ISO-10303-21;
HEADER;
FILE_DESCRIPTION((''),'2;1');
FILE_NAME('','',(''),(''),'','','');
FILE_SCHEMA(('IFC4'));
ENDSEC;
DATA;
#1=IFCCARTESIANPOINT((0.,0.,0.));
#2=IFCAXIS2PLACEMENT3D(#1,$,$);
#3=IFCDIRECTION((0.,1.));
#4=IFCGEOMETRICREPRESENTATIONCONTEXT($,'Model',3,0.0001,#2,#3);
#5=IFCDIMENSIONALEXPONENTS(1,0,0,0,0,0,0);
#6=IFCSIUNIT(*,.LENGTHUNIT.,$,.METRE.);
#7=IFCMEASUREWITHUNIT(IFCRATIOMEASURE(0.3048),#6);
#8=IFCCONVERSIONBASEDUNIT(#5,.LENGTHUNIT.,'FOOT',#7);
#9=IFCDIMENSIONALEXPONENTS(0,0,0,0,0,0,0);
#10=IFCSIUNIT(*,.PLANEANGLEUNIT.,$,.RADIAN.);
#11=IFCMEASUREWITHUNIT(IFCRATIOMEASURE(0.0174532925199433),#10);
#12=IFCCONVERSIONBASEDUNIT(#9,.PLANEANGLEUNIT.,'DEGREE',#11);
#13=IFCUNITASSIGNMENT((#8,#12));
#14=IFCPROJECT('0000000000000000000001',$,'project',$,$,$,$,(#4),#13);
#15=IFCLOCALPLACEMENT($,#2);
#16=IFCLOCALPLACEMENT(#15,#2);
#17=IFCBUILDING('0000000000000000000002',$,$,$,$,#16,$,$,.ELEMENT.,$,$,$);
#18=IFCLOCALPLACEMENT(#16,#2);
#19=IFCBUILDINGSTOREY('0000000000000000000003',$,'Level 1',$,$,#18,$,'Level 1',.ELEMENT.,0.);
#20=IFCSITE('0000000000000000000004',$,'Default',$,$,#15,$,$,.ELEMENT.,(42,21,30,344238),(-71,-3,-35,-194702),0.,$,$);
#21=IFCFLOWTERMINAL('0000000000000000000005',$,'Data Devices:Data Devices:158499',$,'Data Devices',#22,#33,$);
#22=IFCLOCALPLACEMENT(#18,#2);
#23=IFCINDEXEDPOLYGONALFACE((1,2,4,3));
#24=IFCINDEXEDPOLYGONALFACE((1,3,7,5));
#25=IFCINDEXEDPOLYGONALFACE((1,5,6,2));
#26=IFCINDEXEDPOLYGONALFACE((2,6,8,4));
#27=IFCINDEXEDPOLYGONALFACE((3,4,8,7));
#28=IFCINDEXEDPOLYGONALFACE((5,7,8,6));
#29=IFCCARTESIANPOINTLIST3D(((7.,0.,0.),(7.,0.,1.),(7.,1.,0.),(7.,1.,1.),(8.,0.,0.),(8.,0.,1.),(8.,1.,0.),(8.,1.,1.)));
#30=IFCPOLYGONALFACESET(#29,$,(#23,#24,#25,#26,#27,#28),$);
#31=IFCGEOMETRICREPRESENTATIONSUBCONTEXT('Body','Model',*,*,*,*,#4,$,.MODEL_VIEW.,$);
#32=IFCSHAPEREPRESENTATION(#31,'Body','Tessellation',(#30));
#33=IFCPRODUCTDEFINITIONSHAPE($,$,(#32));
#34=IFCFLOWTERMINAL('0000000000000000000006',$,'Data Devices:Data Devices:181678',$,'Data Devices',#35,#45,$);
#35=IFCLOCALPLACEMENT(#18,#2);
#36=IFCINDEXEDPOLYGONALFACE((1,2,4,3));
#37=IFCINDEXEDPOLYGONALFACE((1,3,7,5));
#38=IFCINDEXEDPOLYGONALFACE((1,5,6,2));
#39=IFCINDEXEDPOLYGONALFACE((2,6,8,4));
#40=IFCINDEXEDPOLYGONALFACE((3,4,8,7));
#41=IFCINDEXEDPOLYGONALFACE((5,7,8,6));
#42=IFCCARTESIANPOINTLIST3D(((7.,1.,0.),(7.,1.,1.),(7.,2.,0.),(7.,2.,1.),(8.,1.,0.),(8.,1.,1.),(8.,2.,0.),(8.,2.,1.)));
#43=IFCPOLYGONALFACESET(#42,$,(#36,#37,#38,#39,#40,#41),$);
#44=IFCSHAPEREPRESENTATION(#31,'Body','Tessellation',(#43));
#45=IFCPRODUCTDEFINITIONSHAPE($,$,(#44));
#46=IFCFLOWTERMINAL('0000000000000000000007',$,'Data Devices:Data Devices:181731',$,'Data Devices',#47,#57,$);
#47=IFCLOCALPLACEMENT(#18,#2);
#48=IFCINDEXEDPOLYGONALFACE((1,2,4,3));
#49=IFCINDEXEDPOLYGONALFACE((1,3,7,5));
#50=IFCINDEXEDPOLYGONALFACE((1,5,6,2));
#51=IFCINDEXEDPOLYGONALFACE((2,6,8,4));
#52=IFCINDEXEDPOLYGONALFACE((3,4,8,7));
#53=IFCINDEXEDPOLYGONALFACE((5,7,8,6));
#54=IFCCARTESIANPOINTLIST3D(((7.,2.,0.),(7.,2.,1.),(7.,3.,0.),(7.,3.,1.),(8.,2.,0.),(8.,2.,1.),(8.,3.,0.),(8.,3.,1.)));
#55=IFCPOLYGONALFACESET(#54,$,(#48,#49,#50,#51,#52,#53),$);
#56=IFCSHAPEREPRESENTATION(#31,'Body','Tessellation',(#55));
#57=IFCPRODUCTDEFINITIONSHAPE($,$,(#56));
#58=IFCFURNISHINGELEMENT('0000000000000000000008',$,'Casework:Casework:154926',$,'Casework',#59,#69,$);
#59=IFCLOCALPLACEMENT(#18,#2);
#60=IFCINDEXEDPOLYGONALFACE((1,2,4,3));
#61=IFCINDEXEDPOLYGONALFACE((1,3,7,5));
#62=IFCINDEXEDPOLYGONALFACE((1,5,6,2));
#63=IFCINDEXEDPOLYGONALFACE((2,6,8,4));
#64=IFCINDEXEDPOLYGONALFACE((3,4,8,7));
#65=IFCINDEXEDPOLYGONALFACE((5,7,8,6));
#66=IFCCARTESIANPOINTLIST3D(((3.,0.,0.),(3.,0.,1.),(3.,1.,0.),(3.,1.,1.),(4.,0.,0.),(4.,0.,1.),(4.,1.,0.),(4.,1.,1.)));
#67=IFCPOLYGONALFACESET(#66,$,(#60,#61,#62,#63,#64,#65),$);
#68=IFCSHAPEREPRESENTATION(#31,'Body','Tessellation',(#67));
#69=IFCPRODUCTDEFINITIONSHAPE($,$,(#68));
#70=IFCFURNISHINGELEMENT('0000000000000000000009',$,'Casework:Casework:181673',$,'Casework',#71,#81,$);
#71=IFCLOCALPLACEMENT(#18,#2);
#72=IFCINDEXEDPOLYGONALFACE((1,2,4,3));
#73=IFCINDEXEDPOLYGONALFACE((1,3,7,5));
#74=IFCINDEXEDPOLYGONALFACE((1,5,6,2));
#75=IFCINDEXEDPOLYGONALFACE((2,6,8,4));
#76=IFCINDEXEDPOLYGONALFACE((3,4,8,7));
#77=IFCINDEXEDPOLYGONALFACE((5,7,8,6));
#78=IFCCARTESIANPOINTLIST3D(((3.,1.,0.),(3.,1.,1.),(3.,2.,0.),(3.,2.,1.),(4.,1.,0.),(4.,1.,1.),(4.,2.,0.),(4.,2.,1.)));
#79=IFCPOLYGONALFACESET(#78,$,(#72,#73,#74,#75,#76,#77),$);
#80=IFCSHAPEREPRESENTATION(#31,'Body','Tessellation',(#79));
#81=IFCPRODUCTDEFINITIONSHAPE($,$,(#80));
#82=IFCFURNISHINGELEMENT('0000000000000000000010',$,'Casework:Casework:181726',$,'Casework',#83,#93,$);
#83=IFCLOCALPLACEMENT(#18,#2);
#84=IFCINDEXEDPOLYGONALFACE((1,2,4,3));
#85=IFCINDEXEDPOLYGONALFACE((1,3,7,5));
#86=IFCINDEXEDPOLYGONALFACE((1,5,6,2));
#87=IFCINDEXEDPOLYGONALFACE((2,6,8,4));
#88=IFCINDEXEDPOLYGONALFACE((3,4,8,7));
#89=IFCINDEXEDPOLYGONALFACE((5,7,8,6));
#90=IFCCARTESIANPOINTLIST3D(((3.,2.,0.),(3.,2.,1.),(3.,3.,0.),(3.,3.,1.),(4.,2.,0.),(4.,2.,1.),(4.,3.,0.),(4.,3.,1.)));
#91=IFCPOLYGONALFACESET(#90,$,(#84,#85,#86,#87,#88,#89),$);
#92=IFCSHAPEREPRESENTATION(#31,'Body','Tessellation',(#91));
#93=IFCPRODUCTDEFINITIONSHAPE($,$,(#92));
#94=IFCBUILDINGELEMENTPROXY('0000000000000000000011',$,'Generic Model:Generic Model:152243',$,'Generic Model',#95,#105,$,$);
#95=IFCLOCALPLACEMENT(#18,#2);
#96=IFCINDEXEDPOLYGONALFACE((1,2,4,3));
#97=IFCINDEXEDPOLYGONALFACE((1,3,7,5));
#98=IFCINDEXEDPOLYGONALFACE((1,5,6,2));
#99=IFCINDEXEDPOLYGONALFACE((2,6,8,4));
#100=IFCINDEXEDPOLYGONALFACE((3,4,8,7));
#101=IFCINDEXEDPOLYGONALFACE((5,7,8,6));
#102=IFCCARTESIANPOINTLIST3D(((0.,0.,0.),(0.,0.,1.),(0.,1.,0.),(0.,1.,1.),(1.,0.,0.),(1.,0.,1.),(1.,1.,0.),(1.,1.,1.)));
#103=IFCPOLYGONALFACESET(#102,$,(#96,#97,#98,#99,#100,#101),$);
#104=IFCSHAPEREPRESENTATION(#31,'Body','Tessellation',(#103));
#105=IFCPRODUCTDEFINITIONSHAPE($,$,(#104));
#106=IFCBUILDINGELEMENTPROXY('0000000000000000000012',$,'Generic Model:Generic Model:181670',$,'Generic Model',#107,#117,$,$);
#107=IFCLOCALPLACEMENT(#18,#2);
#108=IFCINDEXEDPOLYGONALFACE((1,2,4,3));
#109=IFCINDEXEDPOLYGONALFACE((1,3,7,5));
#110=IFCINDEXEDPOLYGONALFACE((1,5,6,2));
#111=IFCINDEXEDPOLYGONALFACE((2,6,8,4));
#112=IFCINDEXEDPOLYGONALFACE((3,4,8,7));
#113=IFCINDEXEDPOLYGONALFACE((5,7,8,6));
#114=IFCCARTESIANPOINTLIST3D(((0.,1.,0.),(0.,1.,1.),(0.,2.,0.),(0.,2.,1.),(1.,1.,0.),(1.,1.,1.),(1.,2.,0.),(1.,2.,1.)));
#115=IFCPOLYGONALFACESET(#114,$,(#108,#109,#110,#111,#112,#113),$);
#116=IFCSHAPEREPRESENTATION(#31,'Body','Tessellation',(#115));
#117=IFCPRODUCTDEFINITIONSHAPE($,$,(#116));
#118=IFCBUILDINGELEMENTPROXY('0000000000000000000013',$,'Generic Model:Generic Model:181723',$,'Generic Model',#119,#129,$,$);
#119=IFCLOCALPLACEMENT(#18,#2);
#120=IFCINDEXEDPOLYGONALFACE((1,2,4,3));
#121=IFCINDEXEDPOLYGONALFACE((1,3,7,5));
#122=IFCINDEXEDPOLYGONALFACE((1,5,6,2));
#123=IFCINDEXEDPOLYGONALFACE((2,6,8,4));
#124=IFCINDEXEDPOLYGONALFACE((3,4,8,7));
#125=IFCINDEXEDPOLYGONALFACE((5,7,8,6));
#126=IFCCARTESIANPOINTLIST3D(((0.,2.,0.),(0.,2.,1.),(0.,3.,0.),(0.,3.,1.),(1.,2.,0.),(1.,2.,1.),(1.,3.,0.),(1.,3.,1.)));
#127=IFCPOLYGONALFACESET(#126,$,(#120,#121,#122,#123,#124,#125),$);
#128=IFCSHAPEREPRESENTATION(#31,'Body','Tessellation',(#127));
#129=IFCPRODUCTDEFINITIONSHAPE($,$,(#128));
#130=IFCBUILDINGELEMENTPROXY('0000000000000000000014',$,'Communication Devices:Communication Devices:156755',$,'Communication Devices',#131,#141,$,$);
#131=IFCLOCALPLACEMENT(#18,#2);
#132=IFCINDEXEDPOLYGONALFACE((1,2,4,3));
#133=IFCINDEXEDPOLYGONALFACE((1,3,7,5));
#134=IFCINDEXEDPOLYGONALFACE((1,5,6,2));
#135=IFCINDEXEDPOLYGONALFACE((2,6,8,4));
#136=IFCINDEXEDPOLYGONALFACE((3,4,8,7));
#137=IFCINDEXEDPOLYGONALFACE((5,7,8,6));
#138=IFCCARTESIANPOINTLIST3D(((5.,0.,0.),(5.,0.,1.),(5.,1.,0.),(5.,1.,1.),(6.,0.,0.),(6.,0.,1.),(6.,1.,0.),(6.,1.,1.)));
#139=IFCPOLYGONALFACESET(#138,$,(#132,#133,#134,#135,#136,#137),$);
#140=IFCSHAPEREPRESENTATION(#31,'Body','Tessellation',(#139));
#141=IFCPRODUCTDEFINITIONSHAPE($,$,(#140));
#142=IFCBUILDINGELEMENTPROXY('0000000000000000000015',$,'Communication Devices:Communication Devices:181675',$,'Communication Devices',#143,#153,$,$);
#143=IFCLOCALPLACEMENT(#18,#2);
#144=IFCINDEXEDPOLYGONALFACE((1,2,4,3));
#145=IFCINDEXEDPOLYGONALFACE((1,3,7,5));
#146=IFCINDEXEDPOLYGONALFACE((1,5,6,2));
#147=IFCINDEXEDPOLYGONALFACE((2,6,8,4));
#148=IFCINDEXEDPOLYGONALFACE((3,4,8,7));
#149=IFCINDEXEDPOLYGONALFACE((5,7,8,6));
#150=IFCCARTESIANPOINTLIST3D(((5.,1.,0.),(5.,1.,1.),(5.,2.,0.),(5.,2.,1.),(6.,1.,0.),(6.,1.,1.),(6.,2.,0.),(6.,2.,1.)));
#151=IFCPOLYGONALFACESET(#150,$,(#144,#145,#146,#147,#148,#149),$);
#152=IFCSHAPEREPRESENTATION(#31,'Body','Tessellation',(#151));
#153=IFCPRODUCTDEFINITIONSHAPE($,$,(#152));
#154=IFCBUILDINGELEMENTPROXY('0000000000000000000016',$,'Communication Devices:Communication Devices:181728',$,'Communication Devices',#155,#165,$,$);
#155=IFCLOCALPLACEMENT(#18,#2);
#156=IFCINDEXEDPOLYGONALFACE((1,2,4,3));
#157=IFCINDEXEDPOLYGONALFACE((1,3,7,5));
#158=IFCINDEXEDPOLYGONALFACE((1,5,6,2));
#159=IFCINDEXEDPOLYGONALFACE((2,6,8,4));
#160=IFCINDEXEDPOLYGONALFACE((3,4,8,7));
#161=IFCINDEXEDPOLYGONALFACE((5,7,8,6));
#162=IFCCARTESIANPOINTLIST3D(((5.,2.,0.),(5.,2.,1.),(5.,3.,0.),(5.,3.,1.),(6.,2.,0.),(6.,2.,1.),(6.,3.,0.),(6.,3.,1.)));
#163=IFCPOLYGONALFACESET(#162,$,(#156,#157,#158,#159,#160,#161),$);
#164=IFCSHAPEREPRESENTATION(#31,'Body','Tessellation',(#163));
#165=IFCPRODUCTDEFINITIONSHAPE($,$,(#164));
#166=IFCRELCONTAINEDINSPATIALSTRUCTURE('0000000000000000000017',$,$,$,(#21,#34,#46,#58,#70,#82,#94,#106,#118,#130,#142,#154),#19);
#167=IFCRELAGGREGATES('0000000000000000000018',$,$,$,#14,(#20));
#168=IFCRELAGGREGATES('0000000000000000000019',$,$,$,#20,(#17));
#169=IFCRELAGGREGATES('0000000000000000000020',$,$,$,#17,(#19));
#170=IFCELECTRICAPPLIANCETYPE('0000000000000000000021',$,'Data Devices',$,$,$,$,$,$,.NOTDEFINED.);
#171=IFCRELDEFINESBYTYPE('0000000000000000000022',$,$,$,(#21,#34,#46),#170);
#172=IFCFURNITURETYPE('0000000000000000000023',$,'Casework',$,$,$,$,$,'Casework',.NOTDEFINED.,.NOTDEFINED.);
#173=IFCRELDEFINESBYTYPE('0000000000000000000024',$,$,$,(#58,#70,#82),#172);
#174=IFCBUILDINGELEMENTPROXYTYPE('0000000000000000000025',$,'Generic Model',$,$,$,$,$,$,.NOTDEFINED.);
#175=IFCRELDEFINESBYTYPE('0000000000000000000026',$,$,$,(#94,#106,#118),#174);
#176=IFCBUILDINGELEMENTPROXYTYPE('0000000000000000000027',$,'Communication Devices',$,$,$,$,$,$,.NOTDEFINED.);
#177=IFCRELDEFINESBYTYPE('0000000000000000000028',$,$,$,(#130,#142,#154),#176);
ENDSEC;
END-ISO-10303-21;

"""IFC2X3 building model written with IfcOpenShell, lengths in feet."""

from ifc_helpers import new_model, entity, si_unit, converted_unit, direction, frame, frame_2d, origin, place, context, subcontext, project, spatial, rectangle, extrude, source, transform, mapped, type_object, type_shapes, element, save


model = new_model("IFC2X3")

# Units and contexts
model_context = context("Model", 3, precision=0.0001, world=origin(), true_north=direction((0.0, 1.0)))
body_context = subcontext(model_context, "Body", "Model", "MODEL_VIEW")
ifc_project = project(units=[converted_unit("LENGTHUNIT", "FOOT", entity("IfcRatioMeasure", 0.3048), si_unit("LENGTHUNIT", "METRE"), dimensions=[1, 0, 0, 0, 0, 0, 0]), converted_unit("PLANEANGLEUNIT", "DEGREE", entity("IfcRatioMeasure", 0.0174532925199433), si_unit("PLANEANGLEUNIT", "RADIAN"), dimensions=[0, 0, 0, 0, 0, 0, 0])], contexts=[model_context])

# Site, building, storey
site_placement = place(None, origin())
site = spatial("IfcSite", under=ifc_project, at=site_placement, Name="Default", CompositionType="ELEMENT", RefLatitude=(42, 21, 30, 344238), RefLongitude=(-71, -3, -35, -194702), RefElevation=0.0)
building_placement = place(site_placement, origin())
building = spatial("IfcBuilding", under=site, at=building_placement, CompositionType="ELEMENT")
storey_placement = place(building_placement, origin())
storey = spatial("IfcBuildingStorey", under=building, at=storey_placement, Name="Level 1", LongName="Level 1", CompositionType="ELEMENT", Elevation=0.0)

# Flow terminals
electric_appliance_type = type_object("IfcElectricApplianceType", Name="Data Devices", PredefinedType="NOTDEFINED")
shared_shape_1 = source(origin(), body_context, "Body", "SweptSolid", [
    extrude(rectangle(XDim=1.0, YDim=1.0, at=frame_2d((0.0, 0.0), x_axis=(1.0, 0.0))), frame((0.5, 0.5, 0.0), z_axis=(0.0, 0.0, 1.0), x_axis=(0.0, 1.0, 0.0)), (0.0, 0.0, 1.0), 1.0),
])
type_shapes(electric_appliance_type, [shared_shape_1])
for number, where, name in (
    (1, (7.0, 0.0, 0.0), "Data Devices:Data Devices:158499"),
    (2, (7.0, 1.0, 0.0), "Data Devices:Data Devices:181678"),
    (3, (7.0, 2.0, 0.0), "Data Devices:Data Devices:181731"),
):
    element("IfcFlowTerminal", number, at=place(storey_placement, frame(where)), inside=storey, type_object=electric_appliance_type, Name=name, ObjectType="Data Devices", context=body_context, shape_type="MappedRepresentation", body=[
        mapped(shared_shape_1, transform((0.0, 0.0, 0.0), scale=1.0)),
    ])

# Furnishing elements
furniture_type = type_object("IfcFurnitureType", Name="Casework", ElementType="Casework")
shared_shape_2 = source(origin(), body_context, "Body", "SweptSolid", [
    extrude(rectangle(XDim=1.0, YDim=1.0, at=frame_2d((0.0, 0.0), x_axis=(1.0, 0.0))), frame((0.5, 0.5, 0.0), z_axis=(0.0, 0.0, 1.0), x_axis=(0.0, 1.0, 0.0)), (0.0, 0.0, 1.0), 1.0),
])
type_shapes(furniture_type, [shared_shape_2])
for number, where, name in (
    (4, (3.0, 0.0, 0.0), "Casework:Casework:154926"),
    (5, (3.0, 1.0, 0.0), "Casework:Casework:181673"),
    (6, (3.0, 2.0, 0.0), "Casework:Casework:181726"),
):
    element("IfcFurnishingElement", number, at=place(storey_placement, frame(where)), inside=storey, type_object=furniture_type, Name=name, ObjectType="Casework", context=body_context, shape_type="MappedRepresentation", body=[
        mapped(shared_shape_2, transform((0.0, 0.0, 0.0), scale=1.0)),
    ])

# Building element proxies
building_element_proxy_type_1 = type_object("IfcBuildingElementProxyType", Name="Generic Model", PredefinedType="NOTDEFINED")
shared_shape_3 = source(origin(), body_context, "Body", "SweptSolid", [
    extrude(rectangle(XDim=1.0, YDim=1.0, at=frame_2d((0.0, 0.0), x_axis=(1.0, 0.0))), frame((0.5, 0.5, 0.0), z_axis=(0.0, 0.0, 1.0), x_axis=(0.0, 1.0, 0.0)), (0.0, 0.0, 1.0), 1.0),
])
type_shapes(building_element_proxy_type_1, [shared_shape_3])
for number, where, name in (
    (7, (0.0, 0.0, 0.0), "Generic Model:Generic Model:152243"),
    (8, (0.0, 1.0, 0.0), "Generic Model:Generic Model:181670"),
    (9, (0.0, 2.0, 0.0), "Generic Model:Generic Model:181723"),
):
    element("IfcBuildingElementProxy", number, at=place(storey_placement, frame(where)), inside=storey, type_object=building_element_proxy_type_1, Name=name, ObjectType="Generic Model", context=body_context, shape_type="MappedRepresentation", body=[
        mapped(shared_shape_3, transform((0.0, 0.0, 0.0), scale=1.0)),
    ])
building_element_proxy_type_2 = type_object("IfcBuildingElementProxyType", Name="Communication Devices", PredefinedType="NOTDEFINED")
shared_shape_4 = source(origin(), body_context, "Body", "SweptSolid", [
    extrude(rectangle(XDim=1.0, YDim=1.0, at=frame_2d((0.0, 0.0), x_axis=(1.0, 0.0))), frame((0.5, 0.5, 0.0), z_axis=(0.0, 0.0, 1.0), x_axis=(0.0, 1.0, 0.0)), (0.0, 0.0, 1.0), 1.0),
])
type_shapes(building_element_proxy_type_2, [shared_shape_4])
for number, where, name in (
    (10, (5.0, 0.0, 0.0), "Communication Devices:Communication Devices:156755"),
    (11, (5.0, 1.0, 0.0), "Communication Devices:Communication Devices:181675"),
    (12, (5.0, 2.0, 0.0), "Communication Devices:Communication Devices:181728"),
):
    element("IfcBuildingElementProxy", number, at=place(storey_placement, frame(where)), inside=storey, type_object=building_element_proxy_type_2, Name=name, ObjectType="Communication Devices", context=body_context, shape_type="MappedRepresentation", body=[
        mapped(shared_shape_4, transform((0.0, 0.0, 0.0), scale=1.0)),
    ])

save(model, "model.ifc")
